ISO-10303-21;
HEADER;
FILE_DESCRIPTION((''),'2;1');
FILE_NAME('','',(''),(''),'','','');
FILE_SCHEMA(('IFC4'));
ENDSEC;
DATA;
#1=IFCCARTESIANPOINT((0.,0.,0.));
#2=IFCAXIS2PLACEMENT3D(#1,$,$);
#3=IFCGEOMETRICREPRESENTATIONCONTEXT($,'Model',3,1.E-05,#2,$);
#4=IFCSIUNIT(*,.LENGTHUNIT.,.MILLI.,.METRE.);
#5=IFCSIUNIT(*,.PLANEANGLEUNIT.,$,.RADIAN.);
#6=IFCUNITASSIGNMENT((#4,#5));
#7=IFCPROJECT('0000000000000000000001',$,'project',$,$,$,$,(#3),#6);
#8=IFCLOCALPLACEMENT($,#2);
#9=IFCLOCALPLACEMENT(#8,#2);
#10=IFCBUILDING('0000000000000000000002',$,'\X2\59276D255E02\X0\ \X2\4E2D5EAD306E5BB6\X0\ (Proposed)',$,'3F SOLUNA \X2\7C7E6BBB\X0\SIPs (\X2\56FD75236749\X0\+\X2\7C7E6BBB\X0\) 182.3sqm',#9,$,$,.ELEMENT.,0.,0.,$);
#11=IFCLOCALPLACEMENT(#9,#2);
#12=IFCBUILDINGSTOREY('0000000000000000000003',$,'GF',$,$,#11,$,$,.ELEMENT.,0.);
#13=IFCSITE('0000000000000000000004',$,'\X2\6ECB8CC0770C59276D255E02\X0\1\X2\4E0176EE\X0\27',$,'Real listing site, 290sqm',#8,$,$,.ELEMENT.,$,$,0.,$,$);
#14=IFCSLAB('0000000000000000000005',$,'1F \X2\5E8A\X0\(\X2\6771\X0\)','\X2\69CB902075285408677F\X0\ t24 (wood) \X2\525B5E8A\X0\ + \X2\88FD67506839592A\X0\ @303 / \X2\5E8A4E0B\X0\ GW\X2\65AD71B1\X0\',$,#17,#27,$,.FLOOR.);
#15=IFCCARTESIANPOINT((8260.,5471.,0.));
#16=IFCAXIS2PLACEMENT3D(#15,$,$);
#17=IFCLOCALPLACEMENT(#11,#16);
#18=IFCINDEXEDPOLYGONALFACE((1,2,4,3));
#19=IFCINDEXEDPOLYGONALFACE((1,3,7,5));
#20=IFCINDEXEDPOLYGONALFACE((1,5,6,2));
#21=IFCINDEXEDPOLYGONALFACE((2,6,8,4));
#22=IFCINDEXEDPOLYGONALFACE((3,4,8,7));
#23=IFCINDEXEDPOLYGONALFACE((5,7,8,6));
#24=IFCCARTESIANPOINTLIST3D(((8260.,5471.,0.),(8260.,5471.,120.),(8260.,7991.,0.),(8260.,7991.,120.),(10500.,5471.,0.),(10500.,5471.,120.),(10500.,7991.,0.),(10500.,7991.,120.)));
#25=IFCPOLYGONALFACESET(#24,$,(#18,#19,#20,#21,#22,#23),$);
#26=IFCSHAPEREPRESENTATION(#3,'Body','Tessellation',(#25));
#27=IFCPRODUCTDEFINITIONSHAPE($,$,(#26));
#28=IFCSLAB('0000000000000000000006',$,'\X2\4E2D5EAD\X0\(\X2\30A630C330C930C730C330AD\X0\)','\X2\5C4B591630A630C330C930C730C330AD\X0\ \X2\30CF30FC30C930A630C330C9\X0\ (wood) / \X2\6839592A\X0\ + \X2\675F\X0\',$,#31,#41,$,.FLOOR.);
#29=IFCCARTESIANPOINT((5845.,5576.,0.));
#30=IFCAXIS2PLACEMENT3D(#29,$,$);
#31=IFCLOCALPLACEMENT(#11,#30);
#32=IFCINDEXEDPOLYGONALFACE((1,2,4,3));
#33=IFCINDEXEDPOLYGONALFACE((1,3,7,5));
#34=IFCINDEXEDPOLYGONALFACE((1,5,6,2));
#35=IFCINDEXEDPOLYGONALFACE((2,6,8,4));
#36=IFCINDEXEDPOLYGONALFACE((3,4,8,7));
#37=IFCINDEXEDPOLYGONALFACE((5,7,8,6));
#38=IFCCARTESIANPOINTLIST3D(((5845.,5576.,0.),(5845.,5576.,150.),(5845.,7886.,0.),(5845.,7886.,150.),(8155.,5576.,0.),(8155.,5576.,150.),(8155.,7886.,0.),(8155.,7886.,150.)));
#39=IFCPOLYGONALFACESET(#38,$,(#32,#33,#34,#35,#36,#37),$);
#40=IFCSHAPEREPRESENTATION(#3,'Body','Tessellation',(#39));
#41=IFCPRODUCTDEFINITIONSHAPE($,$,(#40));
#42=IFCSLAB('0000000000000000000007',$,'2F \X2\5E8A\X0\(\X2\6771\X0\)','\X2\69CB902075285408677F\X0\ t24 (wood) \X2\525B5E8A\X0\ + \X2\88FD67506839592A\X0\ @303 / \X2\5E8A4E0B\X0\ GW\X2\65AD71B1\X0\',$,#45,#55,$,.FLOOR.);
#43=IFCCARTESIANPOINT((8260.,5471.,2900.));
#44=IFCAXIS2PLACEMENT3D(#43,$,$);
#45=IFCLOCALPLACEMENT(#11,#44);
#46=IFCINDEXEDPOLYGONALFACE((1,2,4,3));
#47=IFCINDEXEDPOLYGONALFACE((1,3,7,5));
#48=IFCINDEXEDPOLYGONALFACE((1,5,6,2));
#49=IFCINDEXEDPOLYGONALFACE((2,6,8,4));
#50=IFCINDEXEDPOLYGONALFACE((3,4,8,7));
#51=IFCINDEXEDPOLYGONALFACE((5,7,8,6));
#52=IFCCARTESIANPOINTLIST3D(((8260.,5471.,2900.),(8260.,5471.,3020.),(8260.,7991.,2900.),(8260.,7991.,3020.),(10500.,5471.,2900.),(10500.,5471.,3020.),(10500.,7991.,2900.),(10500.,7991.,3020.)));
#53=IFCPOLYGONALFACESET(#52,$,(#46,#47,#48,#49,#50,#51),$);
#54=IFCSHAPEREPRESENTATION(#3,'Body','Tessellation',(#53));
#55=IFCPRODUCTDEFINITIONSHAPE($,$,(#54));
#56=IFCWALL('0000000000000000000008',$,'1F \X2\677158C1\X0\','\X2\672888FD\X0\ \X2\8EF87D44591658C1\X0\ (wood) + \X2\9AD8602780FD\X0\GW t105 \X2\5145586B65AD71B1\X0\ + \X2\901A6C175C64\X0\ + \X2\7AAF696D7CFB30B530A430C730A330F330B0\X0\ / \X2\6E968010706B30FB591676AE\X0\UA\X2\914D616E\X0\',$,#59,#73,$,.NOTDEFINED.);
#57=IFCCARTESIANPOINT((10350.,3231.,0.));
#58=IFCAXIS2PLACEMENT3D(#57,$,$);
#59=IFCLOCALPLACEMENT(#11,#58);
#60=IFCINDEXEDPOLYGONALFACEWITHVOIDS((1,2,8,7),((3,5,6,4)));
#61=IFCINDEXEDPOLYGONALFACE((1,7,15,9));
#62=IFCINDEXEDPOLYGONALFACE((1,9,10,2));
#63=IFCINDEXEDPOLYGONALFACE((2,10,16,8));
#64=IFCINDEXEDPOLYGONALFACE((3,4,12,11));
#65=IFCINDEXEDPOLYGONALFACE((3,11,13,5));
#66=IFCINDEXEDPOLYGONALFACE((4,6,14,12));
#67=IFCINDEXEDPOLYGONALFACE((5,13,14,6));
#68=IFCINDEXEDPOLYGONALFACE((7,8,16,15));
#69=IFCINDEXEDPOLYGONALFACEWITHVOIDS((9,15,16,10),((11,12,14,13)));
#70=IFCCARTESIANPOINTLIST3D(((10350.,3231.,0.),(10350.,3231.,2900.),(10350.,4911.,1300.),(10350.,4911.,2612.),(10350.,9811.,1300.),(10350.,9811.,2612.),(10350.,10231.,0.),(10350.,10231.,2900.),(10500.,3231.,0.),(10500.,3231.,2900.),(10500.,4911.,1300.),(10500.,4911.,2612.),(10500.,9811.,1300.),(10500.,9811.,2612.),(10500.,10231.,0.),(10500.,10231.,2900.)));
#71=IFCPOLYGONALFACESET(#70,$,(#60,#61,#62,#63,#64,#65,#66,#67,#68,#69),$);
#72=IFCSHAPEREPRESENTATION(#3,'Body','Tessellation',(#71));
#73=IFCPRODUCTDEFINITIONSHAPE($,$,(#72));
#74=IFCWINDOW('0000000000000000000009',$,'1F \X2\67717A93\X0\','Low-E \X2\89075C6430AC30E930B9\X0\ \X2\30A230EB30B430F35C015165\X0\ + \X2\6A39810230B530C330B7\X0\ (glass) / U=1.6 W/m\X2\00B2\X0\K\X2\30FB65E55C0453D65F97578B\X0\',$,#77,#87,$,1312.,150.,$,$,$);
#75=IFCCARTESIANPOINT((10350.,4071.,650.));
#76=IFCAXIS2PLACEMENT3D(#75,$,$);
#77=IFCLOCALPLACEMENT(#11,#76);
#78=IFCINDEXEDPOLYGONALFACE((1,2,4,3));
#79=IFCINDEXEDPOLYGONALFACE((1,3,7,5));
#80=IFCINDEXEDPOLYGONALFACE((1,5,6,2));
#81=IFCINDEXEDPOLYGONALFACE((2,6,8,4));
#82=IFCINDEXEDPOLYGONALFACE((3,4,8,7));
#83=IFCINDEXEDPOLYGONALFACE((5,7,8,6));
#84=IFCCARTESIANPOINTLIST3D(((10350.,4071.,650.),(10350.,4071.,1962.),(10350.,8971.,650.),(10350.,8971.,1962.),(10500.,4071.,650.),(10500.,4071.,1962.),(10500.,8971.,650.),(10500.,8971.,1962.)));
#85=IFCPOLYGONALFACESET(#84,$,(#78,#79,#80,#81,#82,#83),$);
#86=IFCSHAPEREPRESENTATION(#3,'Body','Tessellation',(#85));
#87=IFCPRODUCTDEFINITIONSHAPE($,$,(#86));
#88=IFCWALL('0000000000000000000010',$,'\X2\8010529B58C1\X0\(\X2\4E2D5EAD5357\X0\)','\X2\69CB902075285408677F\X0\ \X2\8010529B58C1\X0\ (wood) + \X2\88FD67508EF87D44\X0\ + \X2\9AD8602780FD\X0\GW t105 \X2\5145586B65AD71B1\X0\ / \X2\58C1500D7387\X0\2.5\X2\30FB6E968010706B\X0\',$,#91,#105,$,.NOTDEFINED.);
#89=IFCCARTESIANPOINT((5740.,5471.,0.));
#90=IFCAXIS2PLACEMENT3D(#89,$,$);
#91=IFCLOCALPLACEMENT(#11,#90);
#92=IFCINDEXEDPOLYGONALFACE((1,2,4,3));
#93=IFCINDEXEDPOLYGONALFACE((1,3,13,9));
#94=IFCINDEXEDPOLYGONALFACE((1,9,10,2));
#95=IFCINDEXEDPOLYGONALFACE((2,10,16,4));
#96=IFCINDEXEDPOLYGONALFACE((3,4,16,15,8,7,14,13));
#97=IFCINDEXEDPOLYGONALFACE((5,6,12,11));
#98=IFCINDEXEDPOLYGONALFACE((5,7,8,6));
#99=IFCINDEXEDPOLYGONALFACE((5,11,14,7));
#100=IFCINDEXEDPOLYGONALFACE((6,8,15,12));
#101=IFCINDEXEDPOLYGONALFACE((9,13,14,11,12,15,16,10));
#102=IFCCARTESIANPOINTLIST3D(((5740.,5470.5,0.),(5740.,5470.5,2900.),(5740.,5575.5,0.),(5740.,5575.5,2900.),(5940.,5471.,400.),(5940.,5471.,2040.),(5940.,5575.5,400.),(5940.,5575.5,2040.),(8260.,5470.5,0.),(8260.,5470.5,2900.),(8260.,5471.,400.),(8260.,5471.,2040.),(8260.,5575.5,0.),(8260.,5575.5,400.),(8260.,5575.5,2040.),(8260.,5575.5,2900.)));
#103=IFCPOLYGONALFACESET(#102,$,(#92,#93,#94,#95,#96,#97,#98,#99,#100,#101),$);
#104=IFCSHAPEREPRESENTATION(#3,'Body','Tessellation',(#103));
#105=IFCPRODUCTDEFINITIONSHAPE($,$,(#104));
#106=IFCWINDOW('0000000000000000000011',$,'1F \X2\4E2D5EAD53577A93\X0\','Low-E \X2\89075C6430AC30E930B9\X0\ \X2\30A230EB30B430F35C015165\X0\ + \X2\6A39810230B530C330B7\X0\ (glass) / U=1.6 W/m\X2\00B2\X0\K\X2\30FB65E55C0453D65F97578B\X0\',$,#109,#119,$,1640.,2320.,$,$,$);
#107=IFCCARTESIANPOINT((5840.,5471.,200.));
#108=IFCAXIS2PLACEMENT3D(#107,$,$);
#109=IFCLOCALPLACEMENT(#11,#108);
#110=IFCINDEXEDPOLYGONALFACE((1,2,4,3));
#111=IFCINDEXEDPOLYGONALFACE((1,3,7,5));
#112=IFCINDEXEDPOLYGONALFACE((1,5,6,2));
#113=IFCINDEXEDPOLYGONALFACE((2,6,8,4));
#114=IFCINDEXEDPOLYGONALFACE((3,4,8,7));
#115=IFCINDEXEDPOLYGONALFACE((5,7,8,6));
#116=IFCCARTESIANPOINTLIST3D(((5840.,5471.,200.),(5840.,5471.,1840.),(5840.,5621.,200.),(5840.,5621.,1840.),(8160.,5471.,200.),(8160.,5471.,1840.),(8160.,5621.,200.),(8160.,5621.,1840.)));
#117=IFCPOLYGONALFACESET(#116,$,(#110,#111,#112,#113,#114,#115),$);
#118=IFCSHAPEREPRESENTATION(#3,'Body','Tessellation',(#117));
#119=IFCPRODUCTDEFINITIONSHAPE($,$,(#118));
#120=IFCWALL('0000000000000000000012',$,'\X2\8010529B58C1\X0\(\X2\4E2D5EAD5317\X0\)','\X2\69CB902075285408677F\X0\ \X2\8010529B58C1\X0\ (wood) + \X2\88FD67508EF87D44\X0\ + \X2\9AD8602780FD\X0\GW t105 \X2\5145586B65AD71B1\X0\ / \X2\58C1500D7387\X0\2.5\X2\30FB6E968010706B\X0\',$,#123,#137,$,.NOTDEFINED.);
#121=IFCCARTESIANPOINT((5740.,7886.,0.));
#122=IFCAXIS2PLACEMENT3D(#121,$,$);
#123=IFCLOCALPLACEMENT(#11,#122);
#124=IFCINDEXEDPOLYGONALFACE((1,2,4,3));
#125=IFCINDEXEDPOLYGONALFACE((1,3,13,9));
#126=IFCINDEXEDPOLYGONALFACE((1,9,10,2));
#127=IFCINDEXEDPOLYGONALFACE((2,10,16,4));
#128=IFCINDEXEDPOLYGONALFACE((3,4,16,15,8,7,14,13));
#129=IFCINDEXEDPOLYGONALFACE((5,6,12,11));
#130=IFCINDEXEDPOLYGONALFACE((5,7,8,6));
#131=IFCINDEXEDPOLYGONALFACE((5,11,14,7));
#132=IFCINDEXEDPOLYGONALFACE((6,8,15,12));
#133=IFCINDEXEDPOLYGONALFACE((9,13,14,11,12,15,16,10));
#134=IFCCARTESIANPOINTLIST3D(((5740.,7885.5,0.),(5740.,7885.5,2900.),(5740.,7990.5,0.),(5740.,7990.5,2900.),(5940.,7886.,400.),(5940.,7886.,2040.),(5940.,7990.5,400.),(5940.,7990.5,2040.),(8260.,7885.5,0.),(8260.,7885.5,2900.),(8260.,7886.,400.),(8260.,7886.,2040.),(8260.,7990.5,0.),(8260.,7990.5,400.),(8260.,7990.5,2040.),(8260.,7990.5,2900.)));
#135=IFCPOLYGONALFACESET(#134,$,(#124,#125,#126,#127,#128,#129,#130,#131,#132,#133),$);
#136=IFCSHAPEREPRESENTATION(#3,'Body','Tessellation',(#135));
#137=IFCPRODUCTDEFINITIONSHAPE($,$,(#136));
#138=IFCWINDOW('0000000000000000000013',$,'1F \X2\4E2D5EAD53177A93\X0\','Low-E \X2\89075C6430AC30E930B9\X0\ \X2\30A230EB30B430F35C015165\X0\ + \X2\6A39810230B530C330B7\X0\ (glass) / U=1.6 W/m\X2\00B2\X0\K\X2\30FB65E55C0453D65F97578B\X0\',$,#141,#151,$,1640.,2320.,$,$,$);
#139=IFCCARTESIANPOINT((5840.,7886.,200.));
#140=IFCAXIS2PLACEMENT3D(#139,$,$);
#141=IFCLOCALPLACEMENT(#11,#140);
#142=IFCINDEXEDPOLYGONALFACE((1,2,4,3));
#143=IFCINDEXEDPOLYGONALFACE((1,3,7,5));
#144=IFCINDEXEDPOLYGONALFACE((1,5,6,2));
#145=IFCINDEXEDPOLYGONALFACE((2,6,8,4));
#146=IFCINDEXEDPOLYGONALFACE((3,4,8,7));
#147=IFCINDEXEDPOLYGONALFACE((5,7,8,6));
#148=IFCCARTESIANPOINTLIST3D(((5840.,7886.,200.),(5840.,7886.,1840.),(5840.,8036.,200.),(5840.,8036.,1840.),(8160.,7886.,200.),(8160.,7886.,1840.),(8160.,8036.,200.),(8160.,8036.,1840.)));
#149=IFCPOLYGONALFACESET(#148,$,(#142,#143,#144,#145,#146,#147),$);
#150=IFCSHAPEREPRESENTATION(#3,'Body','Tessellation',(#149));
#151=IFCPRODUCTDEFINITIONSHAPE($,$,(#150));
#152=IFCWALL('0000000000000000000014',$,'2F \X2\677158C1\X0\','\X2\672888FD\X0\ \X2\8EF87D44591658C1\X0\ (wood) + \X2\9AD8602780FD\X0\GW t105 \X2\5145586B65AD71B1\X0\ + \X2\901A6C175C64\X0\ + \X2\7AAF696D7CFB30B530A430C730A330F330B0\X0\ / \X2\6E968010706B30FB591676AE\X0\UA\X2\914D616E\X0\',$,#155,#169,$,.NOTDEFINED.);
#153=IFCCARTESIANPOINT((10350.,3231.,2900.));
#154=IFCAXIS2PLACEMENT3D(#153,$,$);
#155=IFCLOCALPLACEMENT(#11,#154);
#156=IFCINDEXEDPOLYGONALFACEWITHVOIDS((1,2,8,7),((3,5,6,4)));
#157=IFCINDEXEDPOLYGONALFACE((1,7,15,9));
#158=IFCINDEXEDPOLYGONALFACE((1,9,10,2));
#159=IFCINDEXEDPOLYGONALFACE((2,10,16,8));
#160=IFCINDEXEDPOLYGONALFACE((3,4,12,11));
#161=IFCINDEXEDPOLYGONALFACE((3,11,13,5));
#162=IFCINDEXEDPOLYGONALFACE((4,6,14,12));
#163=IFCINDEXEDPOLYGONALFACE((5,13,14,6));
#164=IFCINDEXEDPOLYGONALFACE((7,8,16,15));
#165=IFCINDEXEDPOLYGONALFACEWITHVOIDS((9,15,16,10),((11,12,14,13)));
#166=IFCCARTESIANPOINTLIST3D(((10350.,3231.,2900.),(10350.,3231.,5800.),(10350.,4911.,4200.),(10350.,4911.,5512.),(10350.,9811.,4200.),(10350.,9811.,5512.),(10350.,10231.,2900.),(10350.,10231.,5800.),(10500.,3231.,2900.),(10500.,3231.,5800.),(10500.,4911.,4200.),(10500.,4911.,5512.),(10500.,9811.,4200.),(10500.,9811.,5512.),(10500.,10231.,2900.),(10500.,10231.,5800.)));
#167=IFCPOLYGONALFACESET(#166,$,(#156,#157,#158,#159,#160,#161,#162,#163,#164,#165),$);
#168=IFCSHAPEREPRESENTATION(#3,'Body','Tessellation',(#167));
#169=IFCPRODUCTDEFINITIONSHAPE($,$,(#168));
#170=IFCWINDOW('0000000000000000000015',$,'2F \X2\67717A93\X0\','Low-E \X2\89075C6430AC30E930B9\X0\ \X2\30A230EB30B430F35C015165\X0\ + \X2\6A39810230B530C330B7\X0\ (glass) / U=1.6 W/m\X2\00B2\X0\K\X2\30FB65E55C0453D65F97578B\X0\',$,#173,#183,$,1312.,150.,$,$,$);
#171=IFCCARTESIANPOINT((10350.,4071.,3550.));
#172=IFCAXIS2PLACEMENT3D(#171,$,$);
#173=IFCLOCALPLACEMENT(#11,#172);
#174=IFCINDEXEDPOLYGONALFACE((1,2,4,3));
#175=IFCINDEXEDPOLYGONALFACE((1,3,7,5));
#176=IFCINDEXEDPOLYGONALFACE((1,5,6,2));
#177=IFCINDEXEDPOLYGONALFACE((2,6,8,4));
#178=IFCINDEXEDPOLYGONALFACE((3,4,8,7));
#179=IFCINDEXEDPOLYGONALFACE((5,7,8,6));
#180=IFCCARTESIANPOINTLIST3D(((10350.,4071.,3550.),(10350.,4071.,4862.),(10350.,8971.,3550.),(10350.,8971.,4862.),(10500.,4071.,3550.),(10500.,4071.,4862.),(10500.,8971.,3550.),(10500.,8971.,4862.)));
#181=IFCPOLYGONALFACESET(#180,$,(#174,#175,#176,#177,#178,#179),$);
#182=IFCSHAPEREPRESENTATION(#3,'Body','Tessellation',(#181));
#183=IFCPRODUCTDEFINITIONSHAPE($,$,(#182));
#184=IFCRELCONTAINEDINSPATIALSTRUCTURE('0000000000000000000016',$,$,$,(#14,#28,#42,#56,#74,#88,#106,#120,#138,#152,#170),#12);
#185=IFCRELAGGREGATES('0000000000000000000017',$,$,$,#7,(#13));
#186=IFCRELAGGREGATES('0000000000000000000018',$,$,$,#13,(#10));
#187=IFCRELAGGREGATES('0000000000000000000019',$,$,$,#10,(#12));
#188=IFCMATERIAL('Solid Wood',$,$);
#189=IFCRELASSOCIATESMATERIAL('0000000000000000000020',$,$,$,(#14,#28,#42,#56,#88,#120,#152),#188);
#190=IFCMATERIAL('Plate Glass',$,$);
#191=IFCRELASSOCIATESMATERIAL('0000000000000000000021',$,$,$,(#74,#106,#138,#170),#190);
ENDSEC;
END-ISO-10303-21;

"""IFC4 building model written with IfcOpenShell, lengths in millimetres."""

from ifc_helpers import new_model, si_unit, frame, frame_2d, origin, place, context, project, spatial, rectangle, extrude, material, element, fill, save


model = new_model("IFC4")

# Units and contexts
model_context = context("Model", 3, precision=1e-05, world=origin())
ifc_project = project(units=[si_unit("LENGTHUNIT", "METRE", prefix="MILLI"), si_unit("PLANEANGLEUNIT", "RADIAN")], contexts=[model_context])

# Site, building, storey
site_placement = place(None, origin())
site = spatial("IfcSite", under=ifc_project, at=site_placement, Name="滋賀県大津市1丁目27", ObjectType="Real listing site, 290sqm", CompositionType="ELEMENT", RefElevation=0.0)
building_placement = place(site_placement, origin())
building = spatial("IfcBuilding", under=site, at=building_placement, Name="大津市 中庭の家 (Proposed)", ObjectType="3F SOLUNA 籾殻SIPs (国産杉+籾殻) 182.3sqm", CompositionType="ELEMENT", ElevationOfRefHeight=0.0, ElevationOfTerrain=0.0)
storey_placement = place(building_placement, origin())
storey = spatial("IfcBuildingStorey", under=building, at=storey_placement, Name="GF", CompositionType="ELEMENT", Elevation=0.0)

# Slabs
ifc_material_1 = material(Name="Solid Wood")
slab_1_placement = place(storey_placement, frame((8260.0, 5471.0, 0.0)))
element("IfcSlab", 1, at=slab_1_placement, inside=storey, material=ifc_material_1, Name="1F 床(東)", Description="構造用合板 t24 (wood) 剛床 + 製材根太 @303 / 床下 GW断熱", PredefinedType="FLOOR", context=model_context, shape_type="SweptSolid", body=[
    extrude(rectangle(XDim=2240.0, YDim=2520.0, at=frame_2d((1120.0, 1260.0))), frame((8260.0, 5471.0, 0.0)), (0.0, 0.0, 1.0), 120.0),
])
slab_2_placement = place(storey_placement, frame((5845.0, 5576.0, 0.0)))
element("IfcSlab", 2, at=slab_2_placement, inside=storey, material=ifc_material_1, Name="中庭(ウッドデッキ)", Description="屋外ウッドデッキ ハードウッド (wood) / 根太 + 束", PredefinedType="FLOOR", context=model_context, shape_type="SweptSolid", body=[
    extrude(rectangle(XDim=2310.0, YDim=2310.0, at=frame_2d((1155.0, 1155.0))), frame((5845.0, 5576.0, 0.0)), (0.0, 0.0, 1.0), 150.0),
])
slab_3_placement = place(storey_placement, frame((8260.0, 5471.0, 2900.0)))
element("IfcSlab", 3, at=slab_3_placement, inside=storey, material=ifc_material_1, Name="2F 床(東)", Description="構造用合板 t24 (wood) 剛床 + 製材根太 @303 / 床下 GW断熱", PredefinedType="FLOOR", context=model_context, shape_type="SweptSolid", body=[
    extrude(rectangle(XDim=2240.0, YDim=2520.0, at=frame_2d((1120.0, 1260.0))), frame((8260.0, 5471.0, 2900.0)), (0.0, 0.0, 1.0), 120.0),
])

# Walls, openings, windows
wall_1_placement = place(storey_placement, frame((10350.0, 3231.0, 0.0)))
wall_1 = element("IfcWall", 4, at=wall_1_placement, inside=storey, material=ifc_material_1, Name="1F 東壁", Description="木製 軸組外壁 (wood) + 高性能GW t105 充填断熱 + 通気層 + 窯業系サイディング / 準耐火・外皮UA配慮", PredefinedType="NOTDEFINED", context=model_context, shape_type="SweptSolid", body=[
    extrude(rectangle(XDim=150.0, YDim=7000.0, at=frame_2d((75.0, 3500.0))), frame((10350.0, 3231.0, 0.0)), (0.0, 0.0, 1.0), 2900.0),
])
opening_1_placement = place(storey_placement, frame((10350.0, 4071.0, 650.0)))
opening_1 = element("IfcOpeningElement", 5, at=opening_1_placement, cuts=wall_1, PredefinedType="NOTDEFINED", context=model_context, shape_type="SweptSolid", body=[
    extrude(rectangle(XDim=150.0, YDim=4900.0, at=frame_2d((75.0, 2450.0))), frame((10350.0, 4071.0, 650.0)), (0.0, 0.0, 1.0), 1312.0),
])
ifc_material_2 = material(Name="Plate Glass")
window_1_placement = place(storey_placement, frame((10350.0, 4071.0, 650.0)))
window_1 = element("IfcWindow", 6, at=window_1_placement, inside=storey, material=ifc_material_2, Name="1F 東窓", Description="Low-E 複層ガラス アルゴン封入 + 樹脂サッシ (glass) / U=1.6 W/m²K・日射取得型", OverallHeight=1312.0, OverallWidth=150.0, context=model_context, shape_type="SweptSolid", body=[
    extrude(rectangle(XDim=150.0, YDim=4900.0, at=frame_2d((75.0, 2450.0))), frame((10350.0, 4071.0, 650.0)), (0.0, 0.0, 1.0), 1312.0),
])
fill(opening_1, window_1)
wall_2_placement = place(storey_placement, frame((5740.0, 5471.0, 0.0)))
wall_2 = element("IfcWall", 7, at=wall_2_placement, inside=storey, material=ifc_material_1, Name="耐力壁(中庭南)", Description="構造用合板 耐力壁 (wood) + 製材軸組 + 高性能GW t105 充填断熱 / 壁倍率2.5・準耐火", PredefinedType="NOTDEFINED", context=model_context, shape_type="SweptSolid", body=[
    extrude(rectangle(XDim=2520.0, YDim=105.0, at=frame_2d((1260.0, 52.0))), frame((5740.0, 5471.0, 0.0)), (0.0, 0.0, 1.0), 2900.0),
])
opening_2_placement = place(storey_placement, frame((5840.0, 5471.0, 200.0)))
opening_2 = element("IfcOpeningElement", 8, at=opening_2_placement, cuts=wall_2, PredefinedType="NOTDEFINED", context=model_context, shape_type="SweptSolid", body=[
    extrude(rectangle(XDim=2320.0, YDim=150.0, at=frame_2d((1160.0, 75.0))), frame((5840.0, 5471.0, 200.0)), (0.0, 0.0, 1.0), 1640.0),
])
window_2_placement = place(storey_placement, frame((5840.0, 5471.0, 200.0)))
window_2 = element("IfcWindow", 9, at=window_2_placement, inside=storey, material=ifc_material_2, Name="1F 中庭南窓", Description="Low-E 複層ガラス アルゴン封入 + 樹脂サッシ (glass) / U=1.6 W/m²K・日射取得型", OverallHeight=1640.0, OverallWidth=2320.0, context=model_context, shape_type="SweptSolid", body=[
    extrude(rectangle(XDim=2320.0, YDim=150.0, at=frame_2d((1160.0, 75.0))), frame((5840.0, 5471.0, 200.0)), (0.0, 0.0, 1.0), 1640.0),
])
fill(opening_2, window_2)
wall_3_placement = place(storey_placement, frame((5740.0, 7886.0, 0.0)))
wall_3 = element("IfcWall", 10, at=wall_3_placement, inside=storey, material=ifc_material_1, Name="耐力壁(中庭北)", Description="構造用合板 耐力壁 (wood) + 製材軸組 + 高性能GW t105 充填断熱 / 壁倍率2.5・準耐火", PredefinedType="NOTDEFINED", context=model_context, shape_type="SweptSolid", body=[
    extrude(rectangle(XDim=2520.0, YDim=105.0, at=frame_2d((1260.0, 52.0))), frame((5740.0, 7886.0, 0.0)), (0.0, 0.0, 1.0), 2900.0),
])
opening_3_placement = place(storey_placement, frame((5840.0, 7886.0, 200.0)))
opening_3 = element("IfcOpeningElement", 11, at=opening_3_placement, cuts=wall_3, PredefinedType="NOTDEFINED", context=model_context, shape_type="SweptSolid", body=[
    extrude(rectangle(XDim=2320.0, YDim=150.0, at=frame_2d((1160.0, 75.0))), frame((5840.0, 7886.0, 200.0)), (0.0, 0.0, 1.0), 1640.0),
])
window_3_placement = place(storey_placement, frame((5840.0, 7886.0, 200.0)))
window_3 = element("IfcWindow", 12, at=window_3_placement, inside=storey, material=ifc_material_2, Name="1F 中庭北窓", Description="Low-E 複層ガラス アルゴン封入 + 樹脂サッシ (glass) / U=1.6 W/m²K・日射取得型", OverallHeight=1640.0, OverallWidth=2320.0, context=model_context, shape_type="SweptSolid", body=[
    extrude(rectangle(XDim=2320.0, YDim=150.0, at=frame_2d((1160.0, 75.0))), frame((5840.0, 7886.0, 200.0)), (0.0, 0.0, 1.0), 1640.0),
])
fill(opening_3, window_3)

# Wall, opening, window
wall_4_placement = place(storey_placement, frame((10350.0, 3231.0, 2900.0)))
wall_4 = element("IfcWall", 13, at=wall_4_placement, inside=storey, material=ifc_material_1, Name="2F 東壁", Description="木製 軸組外壁 (wood) + 高性能GW t105 充填断熱 + 通気層 + 窯業系サイディング / 準耐火・外皮UA配慮", PredefinedType="NOTDEFINED", context=model_context, shape_type="SweptSolid", body=[
    extrude(rectangle(XDim=150.0, YDim=7000.0, at=frame_2d((75.0, 3500.0))), frame((10350.0, 3231.0, 2900.0)), (0.0, 0.0, 1.0), 2900.0),
])
opening_4_placement = place(storey_placement, frame((10350.0, 4071.0, 3550.0)))
opening_4 = element("IfcOpeningElement", 14, at=opening_4_placement, cuts=wall_4, PredefinedType="NOTDEFINED", context=model_context, shape_type="SweptSolid", body=[
    extrude(rectangle(XDim=150.0, YDim=4900.0, at=frame_2d((75.0, 2450.0))), frame((10350.0, 4071.0, 3550.0)), (0.0, 0.0, 1.0), 1312.0),
])
window_4_placement = place(storey_placement, frame((10350.0, 4071.0, 3550.0)))
window_4 = element("IfcWindow", 15, at=window_4_placement, inside=storey, material=ifc_material_2, Name="2F 東窓", Description="Low-E 複層ガラス アルゴン封入 + 樹脂サッシ (glass) / U=1.6 W/m²K・日射取得型", OverallHeight=1312.0, OverallWidth=150.0, context=model_context, shape_type="SweptSolid", body=[
    extrude(rectangle(XDim=150.0, YDim=4900.0, at=frame_2d((75.0, 2450.0))), frame((10350.0, 4071.0, 3550.0)), (0.0, 0.0, 1.0), 1312.0),
])
fill(opening_4, window_4)

save(model, "model.ifc")
